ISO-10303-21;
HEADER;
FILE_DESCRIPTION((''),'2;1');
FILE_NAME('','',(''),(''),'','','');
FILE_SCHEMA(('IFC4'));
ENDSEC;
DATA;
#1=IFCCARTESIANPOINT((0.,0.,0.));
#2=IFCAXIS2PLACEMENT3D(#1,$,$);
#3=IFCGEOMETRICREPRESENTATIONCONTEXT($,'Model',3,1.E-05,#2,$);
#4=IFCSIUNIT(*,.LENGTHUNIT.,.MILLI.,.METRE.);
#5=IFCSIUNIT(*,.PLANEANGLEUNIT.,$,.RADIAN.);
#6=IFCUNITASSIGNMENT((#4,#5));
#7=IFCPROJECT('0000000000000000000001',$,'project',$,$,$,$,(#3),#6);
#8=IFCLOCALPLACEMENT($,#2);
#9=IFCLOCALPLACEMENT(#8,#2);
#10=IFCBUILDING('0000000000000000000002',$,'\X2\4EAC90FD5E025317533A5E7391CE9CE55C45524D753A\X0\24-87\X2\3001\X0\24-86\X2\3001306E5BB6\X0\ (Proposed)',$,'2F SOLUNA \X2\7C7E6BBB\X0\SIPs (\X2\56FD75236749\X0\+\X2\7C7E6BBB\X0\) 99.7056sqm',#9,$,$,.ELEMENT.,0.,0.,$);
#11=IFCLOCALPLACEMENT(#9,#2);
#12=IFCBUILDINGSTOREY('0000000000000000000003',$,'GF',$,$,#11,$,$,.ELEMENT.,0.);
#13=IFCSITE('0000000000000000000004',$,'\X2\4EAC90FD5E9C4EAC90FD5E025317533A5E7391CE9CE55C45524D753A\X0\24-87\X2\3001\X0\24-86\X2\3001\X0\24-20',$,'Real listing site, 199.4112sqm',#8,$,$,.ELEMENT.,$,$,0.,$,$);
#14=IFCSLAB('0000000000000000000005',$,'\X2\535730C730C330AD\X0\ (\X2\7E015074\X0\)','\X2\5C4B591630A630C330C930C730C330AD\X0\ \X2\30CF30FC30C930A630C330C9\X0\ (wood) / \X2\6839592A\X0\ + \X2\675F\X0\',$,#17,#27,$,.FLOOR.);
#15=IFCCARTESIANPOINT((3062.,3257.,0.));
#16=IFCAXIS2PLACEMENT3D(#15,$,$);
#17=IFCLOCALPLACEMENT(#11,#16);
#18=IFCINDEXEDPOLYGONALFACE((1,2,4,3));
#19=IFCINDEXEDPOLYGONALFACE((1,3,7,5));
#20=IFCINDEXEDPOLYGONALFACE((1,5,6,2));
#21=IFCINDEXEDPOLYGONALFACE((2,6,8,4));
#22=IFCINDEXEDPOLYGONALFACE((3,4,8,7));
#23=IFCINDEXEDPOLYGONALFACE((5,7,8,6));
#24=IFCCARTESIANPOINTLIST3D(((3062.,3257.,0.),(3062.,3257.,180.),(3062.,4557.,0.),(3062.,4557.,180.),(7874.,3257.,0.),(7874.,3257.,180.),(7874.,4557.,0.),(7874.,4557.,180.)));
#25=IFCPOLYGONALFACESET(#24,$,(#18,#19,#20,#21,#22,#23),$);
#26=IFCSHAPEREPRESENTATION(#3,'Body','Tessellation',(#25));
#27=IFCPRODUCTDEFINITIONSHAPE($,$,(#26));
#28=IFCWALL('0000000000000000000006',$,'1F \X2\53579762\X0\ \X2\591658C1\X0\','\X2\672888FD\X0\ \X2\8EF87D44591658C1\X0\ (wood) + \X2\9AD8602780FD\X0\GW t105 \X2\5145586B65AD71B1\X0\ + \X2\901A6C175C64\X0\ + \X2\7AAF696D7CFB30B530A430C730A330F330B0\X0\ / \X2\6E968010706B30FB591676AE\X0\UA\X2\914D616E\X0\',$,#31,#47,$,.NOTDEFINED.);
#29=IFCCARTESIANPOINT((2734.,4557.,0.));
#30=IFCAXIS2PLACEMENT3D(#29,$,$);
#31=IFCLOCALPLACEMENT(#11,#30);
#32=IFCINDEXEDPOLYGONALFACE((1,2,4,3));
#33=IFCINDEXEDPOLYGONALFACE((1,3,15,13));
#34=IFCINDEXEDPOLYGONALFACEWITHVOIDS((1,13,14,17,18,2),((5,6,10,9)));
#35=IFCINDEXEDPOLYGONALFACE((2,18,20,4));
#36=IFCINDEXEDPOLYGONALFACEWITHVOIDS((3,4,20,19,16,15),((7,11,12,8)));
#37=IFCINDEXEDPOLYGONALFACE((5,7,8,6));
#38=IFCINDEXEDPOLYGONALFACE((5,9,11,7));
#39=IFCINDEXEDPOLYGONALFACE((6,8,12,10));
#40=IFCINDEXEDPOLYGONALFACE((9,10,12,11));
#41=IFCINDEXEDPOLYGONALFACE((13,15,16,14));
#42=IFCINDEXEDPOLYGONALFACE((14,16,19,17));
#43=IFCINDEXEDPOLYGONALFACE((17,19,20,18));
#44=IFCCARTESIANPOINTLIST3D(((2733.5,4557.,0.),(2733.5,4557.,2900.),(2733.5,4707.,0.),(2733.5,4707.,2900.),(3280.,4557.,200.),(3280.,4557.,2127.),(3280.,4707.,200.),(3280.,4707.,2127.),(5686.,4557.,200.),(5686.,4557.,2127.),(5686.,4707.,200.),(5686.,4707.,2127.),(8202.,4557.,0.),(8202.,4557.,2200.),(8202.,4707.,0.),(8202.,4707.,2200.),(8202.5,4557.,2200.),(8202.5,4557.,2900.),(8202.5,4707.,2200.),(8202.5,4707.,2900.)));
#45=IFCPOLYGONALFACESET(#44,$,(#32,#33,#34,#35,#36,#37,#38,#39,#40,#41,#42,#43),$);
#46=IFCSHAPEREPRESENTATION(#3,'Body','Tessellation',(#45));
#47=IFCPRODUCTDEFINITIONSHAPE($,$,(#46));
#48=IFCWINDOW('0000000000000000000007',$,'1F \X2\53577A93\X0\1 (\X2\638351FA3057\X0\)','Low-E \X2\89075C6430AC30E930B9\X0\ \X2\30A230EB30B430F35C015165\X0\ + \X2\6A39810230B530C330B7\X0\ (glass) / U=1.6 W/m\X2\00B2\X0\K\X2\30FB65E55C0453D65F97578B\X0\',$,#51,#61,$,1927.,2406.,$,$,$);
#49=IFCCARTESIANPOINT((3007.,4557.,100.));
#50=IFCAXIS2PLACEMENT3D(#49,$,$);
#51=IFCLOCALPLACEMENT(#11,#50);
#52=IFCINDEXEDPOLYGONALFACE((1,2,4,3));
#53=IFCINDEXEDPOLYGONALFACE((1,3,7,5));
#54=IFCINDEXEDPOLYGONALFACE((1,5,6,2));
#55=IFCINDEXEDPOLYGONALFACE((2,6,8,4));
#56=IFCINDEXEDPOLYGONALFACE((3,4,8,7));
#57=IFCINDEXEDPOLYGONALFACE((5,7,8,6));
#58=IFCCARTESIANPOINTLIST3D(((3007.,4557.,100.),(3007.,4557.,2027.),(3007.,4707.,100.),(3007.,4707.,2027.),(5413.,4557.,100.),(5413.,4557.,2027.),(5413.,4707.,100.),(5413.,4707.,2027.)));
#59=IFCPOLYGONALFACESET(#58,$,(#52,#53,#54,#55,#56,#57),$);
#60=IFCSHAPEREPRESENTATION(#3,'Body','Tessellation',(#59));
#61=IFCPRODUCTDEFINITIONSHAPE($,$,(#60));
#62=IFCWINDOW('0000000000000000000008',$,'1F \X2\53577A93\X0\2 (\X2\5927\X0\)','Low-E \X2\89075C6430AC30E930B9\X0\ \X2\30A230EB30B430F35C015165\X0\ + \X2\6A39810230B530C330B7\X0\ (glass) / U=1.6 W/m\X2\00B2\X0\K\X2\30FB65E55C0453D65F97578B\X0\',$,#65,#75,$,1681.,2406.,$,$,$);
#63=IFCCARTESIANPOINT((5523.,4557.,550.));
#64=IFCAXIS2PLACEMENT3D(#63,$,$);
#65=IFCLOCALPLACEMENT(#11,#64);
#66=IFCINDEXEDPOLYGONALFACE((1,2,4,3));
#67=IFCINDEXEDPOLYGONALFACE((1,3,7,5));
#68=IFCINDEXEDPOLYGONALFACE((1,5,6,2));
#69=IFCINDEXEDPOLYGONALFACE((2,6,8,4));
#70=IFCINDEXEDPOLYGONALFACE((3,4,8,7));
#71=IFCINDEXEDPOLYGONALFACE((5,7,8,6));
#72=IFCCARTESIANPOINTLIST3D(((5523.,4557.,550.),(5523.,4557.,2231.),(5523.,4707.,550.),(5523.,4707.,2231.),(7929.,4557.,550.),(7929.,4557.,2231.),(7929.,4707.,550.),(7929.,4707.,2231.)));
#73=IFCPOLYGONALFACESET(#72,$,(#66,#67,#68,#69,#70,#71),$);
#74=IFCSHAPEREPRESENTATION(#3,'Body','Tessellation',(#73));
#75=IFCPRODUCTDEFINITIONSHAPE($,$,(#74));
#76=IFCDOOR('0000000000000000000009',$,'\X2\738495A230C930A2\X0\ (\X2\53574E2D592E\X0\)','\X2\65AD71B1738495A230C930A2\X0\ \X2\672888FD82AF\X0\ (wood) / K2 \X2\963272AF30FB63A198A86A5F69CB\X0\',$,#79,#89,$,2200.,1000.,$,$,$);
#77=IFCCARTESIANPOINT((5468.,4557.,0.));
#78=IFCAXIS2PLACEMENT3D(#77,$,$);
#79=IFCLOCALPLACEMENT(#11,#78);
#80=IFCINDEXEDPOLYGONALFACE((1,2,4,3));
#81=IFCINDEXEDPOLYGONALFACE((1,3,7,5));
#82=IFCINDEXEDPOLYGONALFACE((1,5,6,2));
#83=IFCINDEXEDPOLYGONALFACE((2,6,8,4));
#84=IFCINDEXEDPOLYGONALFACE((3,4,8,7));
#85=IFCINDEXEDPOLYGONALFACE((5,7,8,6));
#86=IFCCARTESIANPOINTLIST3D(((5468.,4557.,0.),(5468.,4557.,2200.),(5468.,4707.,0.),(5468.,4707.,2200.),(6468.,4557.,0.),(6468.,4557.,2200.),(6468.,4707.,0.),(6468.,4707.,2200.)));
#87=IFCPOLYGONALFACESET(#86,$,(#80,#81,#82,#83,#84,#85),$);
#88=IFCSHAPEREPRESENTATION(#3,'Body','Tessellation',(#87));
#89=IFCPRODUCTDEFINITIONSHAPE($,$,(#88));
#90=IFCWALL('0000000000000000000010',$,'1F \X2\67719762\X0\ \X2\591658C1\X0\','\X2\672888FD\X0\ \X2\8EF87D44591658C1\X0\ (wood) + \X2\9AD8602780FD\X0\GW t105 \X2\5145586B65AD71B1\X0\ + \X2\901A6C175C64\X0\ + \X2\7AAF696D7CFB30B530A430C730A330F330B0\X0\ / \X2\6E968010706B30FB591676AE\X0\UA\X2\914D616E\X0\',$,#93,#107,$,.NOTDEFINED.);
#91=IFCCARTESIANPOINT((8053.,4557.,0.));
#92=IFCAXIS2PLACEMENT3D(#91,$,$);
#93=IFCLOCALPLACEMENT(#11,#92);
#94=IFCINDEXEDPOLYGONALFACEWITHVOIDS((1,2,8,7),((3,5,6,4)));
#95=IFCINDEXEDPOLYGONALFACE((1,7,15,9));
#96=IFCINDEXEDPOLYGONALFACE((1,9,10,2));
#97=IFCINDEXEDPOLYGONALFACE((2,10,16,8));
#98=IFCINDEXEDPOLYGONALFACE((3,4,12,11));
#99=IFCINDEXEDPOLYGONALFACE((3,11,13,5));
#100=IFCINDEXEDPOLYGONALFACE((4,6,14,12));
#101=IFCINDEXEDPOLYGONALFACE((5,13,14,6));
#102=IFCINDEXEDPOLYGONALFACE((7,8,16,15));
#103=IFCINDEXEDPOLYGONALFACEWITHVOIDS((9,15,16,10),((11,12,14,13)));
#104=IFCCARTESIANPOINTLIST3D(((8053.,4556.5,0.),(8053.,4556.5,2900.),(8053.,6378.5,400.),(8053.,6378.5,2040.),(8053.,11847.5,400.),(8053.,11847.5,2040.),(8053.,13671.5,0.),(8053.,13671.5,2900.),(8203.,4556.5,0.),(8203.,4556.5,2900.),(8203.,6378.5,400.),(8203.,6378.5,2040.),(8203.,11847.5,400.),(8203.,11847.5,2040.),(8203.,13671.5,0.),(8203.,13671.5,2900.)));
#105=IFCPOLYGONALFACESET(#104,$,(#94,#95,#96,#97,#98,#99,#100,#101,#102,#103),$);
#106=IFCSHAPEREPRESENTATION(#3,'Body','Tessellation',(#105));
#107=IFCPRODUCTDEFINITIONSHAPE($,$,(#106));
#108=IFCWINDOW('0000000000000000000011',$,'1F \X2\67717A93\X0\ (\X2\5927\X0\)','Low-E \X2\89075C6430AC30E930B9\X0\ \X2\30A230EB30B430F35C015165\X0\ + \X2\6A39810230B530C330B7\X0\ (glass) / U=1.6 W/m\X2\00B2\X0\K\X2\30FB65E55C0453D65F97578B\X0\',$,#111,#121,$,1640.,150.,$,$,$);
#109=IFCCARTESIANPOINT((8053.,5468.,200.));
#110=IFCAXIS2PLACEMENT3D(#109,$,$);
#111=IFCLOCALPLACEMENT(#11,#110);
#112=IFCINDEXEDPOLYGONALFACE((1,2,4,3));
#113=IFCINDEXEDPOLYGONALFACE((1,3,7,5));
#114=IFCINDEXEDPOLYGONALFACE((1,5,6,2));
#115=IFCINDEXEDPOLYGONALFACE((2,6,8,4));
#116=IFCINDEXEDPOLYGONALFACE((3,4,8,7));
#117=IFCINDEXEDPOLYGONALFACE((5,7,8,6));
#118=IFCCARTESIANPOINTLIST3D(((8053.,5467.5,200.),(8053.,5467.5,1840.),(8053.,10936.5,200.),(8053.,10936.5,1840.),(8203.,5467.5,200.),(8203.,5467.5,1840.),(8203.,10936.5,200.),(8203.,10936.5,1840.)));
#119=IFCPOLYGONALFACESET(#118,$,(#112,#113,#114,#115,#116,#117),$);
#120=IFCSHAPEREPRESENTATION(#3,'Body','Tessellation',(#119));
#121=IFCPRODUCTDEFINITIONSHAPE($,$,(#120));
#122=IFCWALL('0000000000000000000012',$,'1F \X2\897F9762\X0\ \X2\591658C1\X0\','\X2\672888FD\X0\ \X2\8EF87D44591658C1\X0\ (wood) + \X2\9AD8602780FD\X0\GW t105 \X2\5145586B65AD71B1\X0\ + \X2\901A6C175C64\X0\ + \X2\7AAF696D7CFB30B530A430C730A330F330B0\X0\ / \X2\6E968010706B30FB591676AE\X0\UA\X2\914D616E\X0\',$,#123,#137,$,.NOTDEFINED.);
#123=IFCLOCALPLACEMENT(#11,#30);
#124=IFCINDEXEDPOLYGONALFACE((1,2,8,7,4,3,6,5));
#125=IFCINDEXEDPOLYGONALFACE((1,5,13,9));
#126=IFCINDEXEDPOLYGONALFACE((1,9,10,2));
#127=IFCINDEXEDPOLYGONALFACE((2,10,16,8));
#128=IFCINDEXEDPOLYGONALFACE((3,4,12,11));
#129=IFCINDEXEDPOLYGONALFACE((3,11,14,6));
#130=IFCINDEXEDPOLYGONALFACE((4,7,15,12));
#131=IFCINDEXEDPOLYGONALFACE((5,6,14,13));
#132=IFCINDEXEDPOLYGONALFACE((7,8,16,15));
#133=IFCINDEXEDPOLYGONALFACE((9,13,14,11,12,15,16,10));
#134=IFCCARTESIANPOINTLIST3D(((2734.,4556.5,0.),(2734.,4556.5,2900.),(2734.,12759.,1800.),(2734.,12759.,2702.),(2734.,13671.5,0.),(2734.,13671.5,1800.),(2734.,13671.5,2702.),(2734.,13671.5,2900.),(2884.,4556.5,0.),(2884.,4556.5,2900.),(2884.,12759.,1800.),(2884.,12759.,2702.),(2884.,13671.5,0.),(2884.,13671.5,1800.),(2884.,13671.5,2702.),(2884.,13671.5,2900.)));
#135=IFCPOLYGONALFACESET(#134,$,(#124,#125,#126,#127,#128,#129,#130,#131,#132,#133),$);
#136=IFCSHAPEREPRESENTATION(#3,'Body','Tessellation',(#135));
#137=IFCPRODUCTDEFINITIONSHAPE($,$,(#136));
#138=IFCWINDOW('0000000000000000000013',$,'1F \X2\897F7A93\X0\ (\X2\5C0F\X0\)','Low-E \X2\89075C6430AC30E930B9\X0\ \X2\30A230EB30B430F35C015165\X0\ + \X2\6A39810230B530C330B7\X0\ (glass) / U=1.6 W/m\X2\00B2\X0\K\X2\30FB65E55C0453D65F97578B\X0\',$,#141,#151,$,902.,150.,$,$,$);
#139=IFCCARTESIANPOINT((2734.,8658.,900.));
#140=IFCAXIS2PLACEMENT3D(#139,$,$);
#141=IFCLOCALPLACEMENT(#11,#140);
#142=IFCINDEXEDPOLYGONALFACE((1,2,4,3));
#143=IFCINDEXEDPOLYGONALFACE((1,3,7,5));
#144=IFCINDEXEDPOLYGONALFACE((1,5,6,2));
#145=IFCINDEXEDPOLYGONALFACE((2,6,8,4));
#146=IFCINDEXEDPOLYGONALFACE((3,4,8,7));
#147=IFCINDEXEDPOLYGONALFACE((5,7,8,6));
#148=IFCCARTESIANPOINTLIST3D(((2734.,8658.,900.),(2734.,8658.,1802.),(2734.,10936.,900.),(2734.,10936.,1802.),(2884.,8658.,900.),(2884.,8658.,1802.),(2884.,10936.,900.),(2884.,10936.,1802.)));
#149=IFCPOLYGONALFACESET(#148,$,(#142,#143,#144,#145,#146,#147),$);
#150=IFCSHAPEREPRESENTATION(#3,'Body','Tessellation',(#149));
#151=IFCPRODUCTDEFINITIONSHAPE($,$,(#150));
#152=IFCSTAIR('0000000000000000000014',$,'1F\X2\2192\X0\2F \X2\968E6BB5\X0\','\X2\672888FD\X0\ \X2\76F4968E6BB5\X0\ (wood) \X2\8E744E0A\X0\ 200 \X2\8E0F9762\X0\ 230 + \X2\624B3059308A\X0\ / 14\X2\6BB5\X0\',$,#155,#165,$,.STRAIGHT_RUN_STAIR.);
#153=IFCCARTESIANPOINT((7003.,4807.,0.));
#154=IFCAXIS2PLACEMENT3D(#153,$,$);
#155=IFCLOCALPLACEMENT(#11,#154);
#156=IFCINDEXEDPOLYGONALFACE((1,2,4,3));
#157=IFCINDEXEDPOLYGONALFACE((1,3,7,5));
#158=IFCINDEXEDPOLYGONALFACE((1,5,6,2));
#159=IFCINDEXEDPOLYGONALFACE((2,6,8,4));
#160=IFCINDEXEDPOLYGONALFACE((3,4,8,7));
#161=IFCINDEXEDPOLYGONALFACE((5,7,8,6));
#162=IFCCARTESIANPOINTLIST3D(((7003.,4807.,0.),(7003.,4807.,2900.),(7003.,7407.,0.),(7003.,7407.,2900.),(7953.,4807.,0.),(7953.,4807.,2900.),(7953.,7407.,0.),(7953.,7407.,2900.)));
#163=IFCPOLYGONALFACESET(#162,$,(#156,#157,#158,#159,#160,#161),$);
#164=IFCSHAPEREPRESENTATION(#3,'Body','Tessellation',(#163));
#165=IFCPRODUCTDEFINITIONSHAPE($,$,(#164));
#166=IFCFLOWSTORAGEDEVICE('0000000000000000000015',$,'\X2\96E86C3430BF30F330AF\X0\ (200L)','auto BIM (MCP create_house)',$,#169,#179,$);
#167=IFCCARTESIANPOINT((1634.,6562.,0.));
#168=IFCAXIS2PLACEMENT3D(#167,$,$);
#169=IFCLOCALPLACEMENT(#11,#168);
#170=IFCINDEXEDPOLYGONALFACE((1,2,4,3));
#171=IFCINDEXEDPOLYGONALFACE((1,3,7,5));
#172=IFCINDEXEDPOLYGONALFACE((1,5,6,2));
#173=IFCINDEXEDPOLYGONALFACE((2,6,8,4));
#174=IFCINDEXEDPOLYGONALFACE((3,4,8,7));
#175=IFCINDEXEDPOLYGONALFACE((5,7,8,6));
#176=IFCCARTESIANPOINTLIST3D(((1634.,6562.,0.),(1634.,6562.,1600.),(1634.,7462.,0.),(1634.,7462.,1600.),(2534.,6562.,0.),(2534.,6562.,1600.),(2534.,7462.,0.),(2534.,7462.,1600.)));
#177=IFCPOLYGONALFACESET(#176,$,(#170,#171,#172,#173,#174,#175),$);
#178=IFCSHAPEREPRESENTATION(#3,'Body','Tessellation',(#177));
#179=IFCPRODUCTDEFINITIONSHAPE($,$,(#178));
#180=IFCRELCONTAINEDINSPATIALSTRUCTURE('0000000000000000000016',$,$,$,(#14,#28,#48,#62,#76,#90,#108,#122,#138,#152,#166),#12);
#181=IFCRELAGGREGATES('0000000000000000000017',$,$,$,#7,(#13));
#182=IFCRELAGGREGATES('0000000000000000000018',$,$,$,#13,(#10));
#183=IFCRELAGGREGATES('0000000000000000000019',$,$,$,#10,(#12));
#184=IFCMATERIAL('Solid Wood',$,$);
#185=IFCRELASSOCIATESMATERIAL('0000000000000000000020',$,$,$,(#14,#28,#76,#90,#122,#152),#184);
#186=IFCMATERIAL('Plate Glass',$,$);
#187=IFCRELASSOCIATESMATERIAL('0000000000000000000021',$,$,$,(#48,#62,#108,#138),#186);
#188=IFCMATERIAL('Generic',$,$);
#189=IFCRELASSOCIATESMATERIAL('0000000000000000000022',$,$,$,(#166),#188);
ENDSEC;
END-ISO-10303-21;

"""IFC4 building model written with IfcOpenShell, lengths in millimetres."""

from ifc_helpers import new_model, si_unit, frame, frame_2d, origin, place, context, project, spatial, rectangle, extrude, material, element, fill, save


model = new_model("IFC4")

# Units and contexts
model_context = context("Model", 3, precision=1e-05, world=origin())
ifc_project = project(units=[si_unit("LENGTHUNIT", "METRE", prefix="MILLI"), si_unit("PLANEANGLEUNIT", "RADIAN")], contexts=[model_context])

# Site, building, storey
site_placement = place(None, origin())
site = spatial("IfcSite", under=ifc_project, at=site_placement, Name="京都府京都市北区平野鳥居前町24-87、24-86、24-20", ObjectType="Real listing site, 199.4112sqm", CompositionType="ELEMENT", RefElevation=0.0)
building_placement = place(site_placement, origin())
building = spatial("IfcBuilding", under=site, at=building_placement, Name="京都市北区平野鳥居前町24-87、24-86、の家 (Proposed)", ObjectType="2F SOLUNA 籾殻SIPs (国産杉+籾殻) 99.7056sqm", CompositionType="ELEMENT", ElevationOfRefHeight=0.0, ElevationOfTerrain=0.0)
storey_placement = place(building_placement, origin())
storey = spatial("IfcBuildingStorey", under=building, at=storey_placement, Name="GF", CompositionType="ELEMENT", Elevation=0.0)

# Slab
ifc_material_1 = material(Name="Solid Wood")
slab_1_placement = place(storey_placement, frame((3062.0, 3257.0, 0.0)))
element("IfcSlab", 1, at=slab_1_placement, inside=storey, material=ifc_material_1, Name="南デッキ (縁側)", Description="屋外ウッドデッキ ハードウッド (wood) / 根太 + 束", PredefinedType="FLOOR", context=model_context, shape_type="SweptSolid", body=[
    extrude(rectangle(XDim=4812.0, YDim=1300.0, at=frame_2d((2406.0, 650.0))), frame((3062.0, 3257.0, 0.0)), (0.0, 0.0, 1.0), 180.0),
])

# Wall, openings, windows, door
wall_1_placement = place(storey_placement, frame((2734.0, 4557.0, 0.0)))
wall_1 = element("IfcWall", 2, at=wall_1_placement, inside=storey, material=ifc_material_1, Name="1F 南面 外壁", Description="木製 軸組外壁 (wood) + 高性能GW t105 充填断熱 + 通気層 + 窯業系サイディング / 準耐火・外皮UA配慮", PredefinedType="NOTDEFINED", context=model_context, shape_type="SweptSolid", body=[
    extrude(rectangle(XDim=5469.0, YDim=150.0, at=frame_2d((2734.0, 75.0))), frame((2734.0, 4557.0, 0.0)), (0.0, 0.0, 1.0), 2900.0),
])
opening_1_placement = place(storey_placement, frame((3007.0, 4557.0, 100.0)))
opening_1 = element("IfcOpeningElement", 3, at=opening_1_placement, cuts=wall_1, PredefinedType="NOTDEFINED", context=model_context, shape_type="SweptSolid", body=[
    extrude(rectangle(XDim=2406.0, YDim=150.0, at=frame_2d((1203.0, 75.0))), frame((3007.0, 4557.0, 100.0)), (0.0, 0.0, 1.0), 1927.0),
])
opening_2_placement = place(storey_placement, frame((5523.0, 4557.0, 550.0)))
opening_2 = element("IfcOpeningElement", 4, at=opening_2_placement, cuts=wall_1, PredefinedType="NOTDEFINED", context=model_context, shape_type="SweptSolid", body=[
    extrude(rectangle(XDim=2406.0, YDim=150.0, at=frame_2d((1203.0, 75.0))), frame((5523.0, 4557.0, 550.0)), (0.0, 0.0, 1.0), 1681.0),
])
opening_3_placement = place(storey_placement, frame((5468.0, 4557.0, 0.0)))
opening_3 = element("IfcOpeningElement", 5, at=opening_3_placement, cuts=wall_1, PredefinedType="NOTDEFINED", context=model_context, shape_type="SweptSolid", body=[
    extrude(rectangle(XDim=1000.0, YDim=150.0, at=frame_2d((500.0, 75.0))), frame((5468.0, 4557.0, 0.0)), (0.0, 0.0, 1.0), 2200.0),
])
ifc_material_2 = material(Name="Plate Glass")
window_1_placement = place(storey_placement, frame((3007.0, 4557.0, 100.0)))
window_1 = element("IfcWindow", 6, at=window_1_placement, inside=storey, material=ifc_material_2, Name="1F 南窓1 (掃出し)", Description="Low-E 複層ガラス アルゴン封入 + 樹脂サッシ (glass) / U=1.6 W/m²K・日射取得型", OverallHeight=1927.0, OverallWidth=2406.0, context=model_context, shape_type="SweptSolid", body=[
    extrude(rectangle(XDim=2406.0, YDim=150.0, at=frame_2d((1203.0, 75.0))), frame((3007.0, 4557.0, 100.0)), (0.0, 0.0, 1.0), 1927.0),
])
fill(opening_1, window_1)
window_2_placement = place(storey_placement, frame((5523.0, 4557.0, 550.0)))
window_2 = element("IfcWindow", 7, at=window_2_placement, inside=storey, material=ifc_material_2, Name="1F 南窓2 (大)", Description="Low-E 複層ガラス アルゴン封入 + 樹脂サッシ (glass) / U=1.6 W/m²K・日射取得型", OverallHeight=1681.0, OverallWidth=2406.0, context=model_context, shape_type="SweptSolid", body=[
    extrude(rectangle(XDim=2406.0, YDim=150.0, at=frame_2d((1203.0, 75.0))), frame((5523.0, 4557.0, 550.0)), (0.0, 0.0, 1.0), 1681.0),
])
fill(opening_2, window_2)
door_placement = place(storey_placement, frame((5468.0, 4557.0, 0.0)))
door = element("IfcDoor", 8, at=door_placement, inside=storey, material=ifc_material_1, Name="玄関ドア (南中央)", Description="断熱玄関ドア 木製芯 (wood) / K2 防犯・採風機構", OverallHeight=2200.0, OverallWidth=1000.0, context=model_context, shape_type="SweptSolid", body=[
    extrude(rectangle(XDim=1000.0, YDim=150.0, at=frame_2d((500.0, 75.0))), frame((5468.0, 4557.0, 0.0)), (0.0, 0.0, 1.0), 2200.0),
])
fill(opening_3, door)

# Walls, openings, windows
wall_2_placement = place(storey_placement, frame((8053.0, 4557.0, 0.0)))
wall_2 = element("IfcWall", 9, at=wall_2_placement, inside=storey, material=ifc_material_1, Name="1F 東面 外壁", Description="木製 軸組外壁 (wood) + 高性能GW t105 充填断熱 + 通気層 + 窯業系サイディング / 準耐火・外皮UA配慮", PredefinedType="NOTDEFINED", context=model_context, shape_type="SweptSolid", body=[
    extrude(rectangle(XDim=150.0, YDim=9115.0, at=frame_2d((75.0, 4557.0))), frame((8053.0, 4557.0, 0.0)), (0.0, 0.0, 1.0), 2900.0),
])
opening_4_placement = place(storey_placement, frame((8053.0, 5468.0, 200.0)))
opening_4 = element("IfcOpeningElement", 10, at=opening_4_placement, cuts=wall_2, PredefinedType="NOTDEFINED", context=model_context, shape_type="SweptSolid", body=[
    extrude(rectangle(XDim=150.0, YDim=5469.0, at=frame_2d((75.0, 2734.0))), frame((8053.0, 5468.0, 200.0)), (0.0, 0.0, 1.0), 1640.0),
])
window_3_placement = place(storey_placement, frame((8053.0, 5468.0, 200.0)))
window_3 = element("IfcWindow", 11, at=window_3_placement, inside=storey, material=ifc_material_2, Name="1F 東窓 (大)", Description="Low-E 複層ガラス アルゴン封入 + 樹脂サッシ (glass) / U=1.6 W/m²K・日射取得型", OverallHeight=1640.0, OverallWidth=150.0, context=model_context, shape_type="SweptSolid", body=[
    extrude(rectangle(XDim=150.0, YDim=5469.0, at=frame_2d((75.0, 2734.0))), frame((8053.0, 5468.0, 200.0)), (0.0, 0.0, 1.0), 1640.0),
])
fill(opening_4, window_3)
wall_3_placement = place(storey_placement, frame((2734.0, 4557.0, 0.0)))
wall_3 = element("IfcWall", 12, at=wall_3_placement, inside=storey, material=ifc_material_1, Name="1F 西面 外壁", Description="木製 軸組外壁 (wood) + 高性能GW t105 充填断熱 + 通気層 + 窯業系サイディング / 準耐火・外皮UA配慮", PredefinedType="NOTDEFINED", context=model_context, shape_type="SweptSolid", body=[
    extrude(rectangle(XDim=150.0, YDim=9115.0, at=frame_2d((75.0, 4557.0))), frame((2734.0, 4557.0, 0.0)), (0.0, 0.0, 1.0), 2900.0),
])
opening_5_placement = place(storey_placement, frame((2734.0, 8658.0, 900.0)))
opening_5 = element("IfcOpeningElement", 13, at=opening_5_placement, cuts=wall_3, PredefinedType="NOTDEFINED", context=model_context, shape_type="SweptSolid", body=[
    extrude(rectangle(XDim=150.0, YDim=2278.0, at=frame_2d((75.0, 1139.0))), frame((2734.0, 8658.0, 900.0)), (0.0, 0.0, 1.0), 902.0),
])
window_4_placement = place(storey_placement, frame((2734.0, 8658.0, 900.0)))
window_4 = element("IfcWindow", 14, at=window_4_placement, inside=storey, material=ifc_material_2, Name="1F 西窓 (小)", Description="Low-E 複層ガラス アルゴン封入 + 樹脂サッシ (glass) / U=1.6 W/m²K・日射取得型", OverallHeight=902.0, OverallWidth=150.0, context=model_context, shape_type="SweptSolid", body=[
    extrude(rectangle(XDim=150.0, YDim=2278.0, at=frame_2d((75.0, 1139.0))), frame((2734.0, 8658.0, 900.0)), (0.0, 0.0, 1.0), 902.0),
])
fill(opening_5, window_4)

# Stair
stair_placement = place(storey_placement, frame((7003.0, 4807.0, 0.0)))
element("IfcStair", 15, at=stair_placement, inside=storey, material=ifc_material_1, Name="1F→2F 階段", Description="木製 直階段 (wood) 蹴上 200 踏面 230 + 手すり / 14段", PredefinedType="STRAIGHT_RUN_STAIR", context=model_context, shape_type="SweptSolid", body=[
    extrude(rectangle(XDim=950.0, YDim=2600.0, at=frame_2d((475.0, 1300.0))), frame((7003.0, 4807.0, 0.0)), (0.0, 0.0, 1.0), 2900.0),
])

# Shared definitions
ifc_material_3 = material(Name="Generic")

# Flow storage device
flow_storage_device_placement = place(storey_placement, frame((1634.0, 6562.0, 0.0)))
element("IfcFlowStorageDevice", 16, at=flow_storage_device_placement, inside=storey, material=ifc_material_3, Name="雨水タンク (200L)", Description="auto BIM (MCP create_house)", context=model_context, shape_type="SweptSolid", body=[
    extrude(rectangle(XDim=900.0, YDim=900.0, at=frame_2d((450.0, 450.0))), frame((1634.0, 6562.0, 0.0)), (0.0, 0.0, 1.0), 1600.0),
])

save(model, "model.ifc")
